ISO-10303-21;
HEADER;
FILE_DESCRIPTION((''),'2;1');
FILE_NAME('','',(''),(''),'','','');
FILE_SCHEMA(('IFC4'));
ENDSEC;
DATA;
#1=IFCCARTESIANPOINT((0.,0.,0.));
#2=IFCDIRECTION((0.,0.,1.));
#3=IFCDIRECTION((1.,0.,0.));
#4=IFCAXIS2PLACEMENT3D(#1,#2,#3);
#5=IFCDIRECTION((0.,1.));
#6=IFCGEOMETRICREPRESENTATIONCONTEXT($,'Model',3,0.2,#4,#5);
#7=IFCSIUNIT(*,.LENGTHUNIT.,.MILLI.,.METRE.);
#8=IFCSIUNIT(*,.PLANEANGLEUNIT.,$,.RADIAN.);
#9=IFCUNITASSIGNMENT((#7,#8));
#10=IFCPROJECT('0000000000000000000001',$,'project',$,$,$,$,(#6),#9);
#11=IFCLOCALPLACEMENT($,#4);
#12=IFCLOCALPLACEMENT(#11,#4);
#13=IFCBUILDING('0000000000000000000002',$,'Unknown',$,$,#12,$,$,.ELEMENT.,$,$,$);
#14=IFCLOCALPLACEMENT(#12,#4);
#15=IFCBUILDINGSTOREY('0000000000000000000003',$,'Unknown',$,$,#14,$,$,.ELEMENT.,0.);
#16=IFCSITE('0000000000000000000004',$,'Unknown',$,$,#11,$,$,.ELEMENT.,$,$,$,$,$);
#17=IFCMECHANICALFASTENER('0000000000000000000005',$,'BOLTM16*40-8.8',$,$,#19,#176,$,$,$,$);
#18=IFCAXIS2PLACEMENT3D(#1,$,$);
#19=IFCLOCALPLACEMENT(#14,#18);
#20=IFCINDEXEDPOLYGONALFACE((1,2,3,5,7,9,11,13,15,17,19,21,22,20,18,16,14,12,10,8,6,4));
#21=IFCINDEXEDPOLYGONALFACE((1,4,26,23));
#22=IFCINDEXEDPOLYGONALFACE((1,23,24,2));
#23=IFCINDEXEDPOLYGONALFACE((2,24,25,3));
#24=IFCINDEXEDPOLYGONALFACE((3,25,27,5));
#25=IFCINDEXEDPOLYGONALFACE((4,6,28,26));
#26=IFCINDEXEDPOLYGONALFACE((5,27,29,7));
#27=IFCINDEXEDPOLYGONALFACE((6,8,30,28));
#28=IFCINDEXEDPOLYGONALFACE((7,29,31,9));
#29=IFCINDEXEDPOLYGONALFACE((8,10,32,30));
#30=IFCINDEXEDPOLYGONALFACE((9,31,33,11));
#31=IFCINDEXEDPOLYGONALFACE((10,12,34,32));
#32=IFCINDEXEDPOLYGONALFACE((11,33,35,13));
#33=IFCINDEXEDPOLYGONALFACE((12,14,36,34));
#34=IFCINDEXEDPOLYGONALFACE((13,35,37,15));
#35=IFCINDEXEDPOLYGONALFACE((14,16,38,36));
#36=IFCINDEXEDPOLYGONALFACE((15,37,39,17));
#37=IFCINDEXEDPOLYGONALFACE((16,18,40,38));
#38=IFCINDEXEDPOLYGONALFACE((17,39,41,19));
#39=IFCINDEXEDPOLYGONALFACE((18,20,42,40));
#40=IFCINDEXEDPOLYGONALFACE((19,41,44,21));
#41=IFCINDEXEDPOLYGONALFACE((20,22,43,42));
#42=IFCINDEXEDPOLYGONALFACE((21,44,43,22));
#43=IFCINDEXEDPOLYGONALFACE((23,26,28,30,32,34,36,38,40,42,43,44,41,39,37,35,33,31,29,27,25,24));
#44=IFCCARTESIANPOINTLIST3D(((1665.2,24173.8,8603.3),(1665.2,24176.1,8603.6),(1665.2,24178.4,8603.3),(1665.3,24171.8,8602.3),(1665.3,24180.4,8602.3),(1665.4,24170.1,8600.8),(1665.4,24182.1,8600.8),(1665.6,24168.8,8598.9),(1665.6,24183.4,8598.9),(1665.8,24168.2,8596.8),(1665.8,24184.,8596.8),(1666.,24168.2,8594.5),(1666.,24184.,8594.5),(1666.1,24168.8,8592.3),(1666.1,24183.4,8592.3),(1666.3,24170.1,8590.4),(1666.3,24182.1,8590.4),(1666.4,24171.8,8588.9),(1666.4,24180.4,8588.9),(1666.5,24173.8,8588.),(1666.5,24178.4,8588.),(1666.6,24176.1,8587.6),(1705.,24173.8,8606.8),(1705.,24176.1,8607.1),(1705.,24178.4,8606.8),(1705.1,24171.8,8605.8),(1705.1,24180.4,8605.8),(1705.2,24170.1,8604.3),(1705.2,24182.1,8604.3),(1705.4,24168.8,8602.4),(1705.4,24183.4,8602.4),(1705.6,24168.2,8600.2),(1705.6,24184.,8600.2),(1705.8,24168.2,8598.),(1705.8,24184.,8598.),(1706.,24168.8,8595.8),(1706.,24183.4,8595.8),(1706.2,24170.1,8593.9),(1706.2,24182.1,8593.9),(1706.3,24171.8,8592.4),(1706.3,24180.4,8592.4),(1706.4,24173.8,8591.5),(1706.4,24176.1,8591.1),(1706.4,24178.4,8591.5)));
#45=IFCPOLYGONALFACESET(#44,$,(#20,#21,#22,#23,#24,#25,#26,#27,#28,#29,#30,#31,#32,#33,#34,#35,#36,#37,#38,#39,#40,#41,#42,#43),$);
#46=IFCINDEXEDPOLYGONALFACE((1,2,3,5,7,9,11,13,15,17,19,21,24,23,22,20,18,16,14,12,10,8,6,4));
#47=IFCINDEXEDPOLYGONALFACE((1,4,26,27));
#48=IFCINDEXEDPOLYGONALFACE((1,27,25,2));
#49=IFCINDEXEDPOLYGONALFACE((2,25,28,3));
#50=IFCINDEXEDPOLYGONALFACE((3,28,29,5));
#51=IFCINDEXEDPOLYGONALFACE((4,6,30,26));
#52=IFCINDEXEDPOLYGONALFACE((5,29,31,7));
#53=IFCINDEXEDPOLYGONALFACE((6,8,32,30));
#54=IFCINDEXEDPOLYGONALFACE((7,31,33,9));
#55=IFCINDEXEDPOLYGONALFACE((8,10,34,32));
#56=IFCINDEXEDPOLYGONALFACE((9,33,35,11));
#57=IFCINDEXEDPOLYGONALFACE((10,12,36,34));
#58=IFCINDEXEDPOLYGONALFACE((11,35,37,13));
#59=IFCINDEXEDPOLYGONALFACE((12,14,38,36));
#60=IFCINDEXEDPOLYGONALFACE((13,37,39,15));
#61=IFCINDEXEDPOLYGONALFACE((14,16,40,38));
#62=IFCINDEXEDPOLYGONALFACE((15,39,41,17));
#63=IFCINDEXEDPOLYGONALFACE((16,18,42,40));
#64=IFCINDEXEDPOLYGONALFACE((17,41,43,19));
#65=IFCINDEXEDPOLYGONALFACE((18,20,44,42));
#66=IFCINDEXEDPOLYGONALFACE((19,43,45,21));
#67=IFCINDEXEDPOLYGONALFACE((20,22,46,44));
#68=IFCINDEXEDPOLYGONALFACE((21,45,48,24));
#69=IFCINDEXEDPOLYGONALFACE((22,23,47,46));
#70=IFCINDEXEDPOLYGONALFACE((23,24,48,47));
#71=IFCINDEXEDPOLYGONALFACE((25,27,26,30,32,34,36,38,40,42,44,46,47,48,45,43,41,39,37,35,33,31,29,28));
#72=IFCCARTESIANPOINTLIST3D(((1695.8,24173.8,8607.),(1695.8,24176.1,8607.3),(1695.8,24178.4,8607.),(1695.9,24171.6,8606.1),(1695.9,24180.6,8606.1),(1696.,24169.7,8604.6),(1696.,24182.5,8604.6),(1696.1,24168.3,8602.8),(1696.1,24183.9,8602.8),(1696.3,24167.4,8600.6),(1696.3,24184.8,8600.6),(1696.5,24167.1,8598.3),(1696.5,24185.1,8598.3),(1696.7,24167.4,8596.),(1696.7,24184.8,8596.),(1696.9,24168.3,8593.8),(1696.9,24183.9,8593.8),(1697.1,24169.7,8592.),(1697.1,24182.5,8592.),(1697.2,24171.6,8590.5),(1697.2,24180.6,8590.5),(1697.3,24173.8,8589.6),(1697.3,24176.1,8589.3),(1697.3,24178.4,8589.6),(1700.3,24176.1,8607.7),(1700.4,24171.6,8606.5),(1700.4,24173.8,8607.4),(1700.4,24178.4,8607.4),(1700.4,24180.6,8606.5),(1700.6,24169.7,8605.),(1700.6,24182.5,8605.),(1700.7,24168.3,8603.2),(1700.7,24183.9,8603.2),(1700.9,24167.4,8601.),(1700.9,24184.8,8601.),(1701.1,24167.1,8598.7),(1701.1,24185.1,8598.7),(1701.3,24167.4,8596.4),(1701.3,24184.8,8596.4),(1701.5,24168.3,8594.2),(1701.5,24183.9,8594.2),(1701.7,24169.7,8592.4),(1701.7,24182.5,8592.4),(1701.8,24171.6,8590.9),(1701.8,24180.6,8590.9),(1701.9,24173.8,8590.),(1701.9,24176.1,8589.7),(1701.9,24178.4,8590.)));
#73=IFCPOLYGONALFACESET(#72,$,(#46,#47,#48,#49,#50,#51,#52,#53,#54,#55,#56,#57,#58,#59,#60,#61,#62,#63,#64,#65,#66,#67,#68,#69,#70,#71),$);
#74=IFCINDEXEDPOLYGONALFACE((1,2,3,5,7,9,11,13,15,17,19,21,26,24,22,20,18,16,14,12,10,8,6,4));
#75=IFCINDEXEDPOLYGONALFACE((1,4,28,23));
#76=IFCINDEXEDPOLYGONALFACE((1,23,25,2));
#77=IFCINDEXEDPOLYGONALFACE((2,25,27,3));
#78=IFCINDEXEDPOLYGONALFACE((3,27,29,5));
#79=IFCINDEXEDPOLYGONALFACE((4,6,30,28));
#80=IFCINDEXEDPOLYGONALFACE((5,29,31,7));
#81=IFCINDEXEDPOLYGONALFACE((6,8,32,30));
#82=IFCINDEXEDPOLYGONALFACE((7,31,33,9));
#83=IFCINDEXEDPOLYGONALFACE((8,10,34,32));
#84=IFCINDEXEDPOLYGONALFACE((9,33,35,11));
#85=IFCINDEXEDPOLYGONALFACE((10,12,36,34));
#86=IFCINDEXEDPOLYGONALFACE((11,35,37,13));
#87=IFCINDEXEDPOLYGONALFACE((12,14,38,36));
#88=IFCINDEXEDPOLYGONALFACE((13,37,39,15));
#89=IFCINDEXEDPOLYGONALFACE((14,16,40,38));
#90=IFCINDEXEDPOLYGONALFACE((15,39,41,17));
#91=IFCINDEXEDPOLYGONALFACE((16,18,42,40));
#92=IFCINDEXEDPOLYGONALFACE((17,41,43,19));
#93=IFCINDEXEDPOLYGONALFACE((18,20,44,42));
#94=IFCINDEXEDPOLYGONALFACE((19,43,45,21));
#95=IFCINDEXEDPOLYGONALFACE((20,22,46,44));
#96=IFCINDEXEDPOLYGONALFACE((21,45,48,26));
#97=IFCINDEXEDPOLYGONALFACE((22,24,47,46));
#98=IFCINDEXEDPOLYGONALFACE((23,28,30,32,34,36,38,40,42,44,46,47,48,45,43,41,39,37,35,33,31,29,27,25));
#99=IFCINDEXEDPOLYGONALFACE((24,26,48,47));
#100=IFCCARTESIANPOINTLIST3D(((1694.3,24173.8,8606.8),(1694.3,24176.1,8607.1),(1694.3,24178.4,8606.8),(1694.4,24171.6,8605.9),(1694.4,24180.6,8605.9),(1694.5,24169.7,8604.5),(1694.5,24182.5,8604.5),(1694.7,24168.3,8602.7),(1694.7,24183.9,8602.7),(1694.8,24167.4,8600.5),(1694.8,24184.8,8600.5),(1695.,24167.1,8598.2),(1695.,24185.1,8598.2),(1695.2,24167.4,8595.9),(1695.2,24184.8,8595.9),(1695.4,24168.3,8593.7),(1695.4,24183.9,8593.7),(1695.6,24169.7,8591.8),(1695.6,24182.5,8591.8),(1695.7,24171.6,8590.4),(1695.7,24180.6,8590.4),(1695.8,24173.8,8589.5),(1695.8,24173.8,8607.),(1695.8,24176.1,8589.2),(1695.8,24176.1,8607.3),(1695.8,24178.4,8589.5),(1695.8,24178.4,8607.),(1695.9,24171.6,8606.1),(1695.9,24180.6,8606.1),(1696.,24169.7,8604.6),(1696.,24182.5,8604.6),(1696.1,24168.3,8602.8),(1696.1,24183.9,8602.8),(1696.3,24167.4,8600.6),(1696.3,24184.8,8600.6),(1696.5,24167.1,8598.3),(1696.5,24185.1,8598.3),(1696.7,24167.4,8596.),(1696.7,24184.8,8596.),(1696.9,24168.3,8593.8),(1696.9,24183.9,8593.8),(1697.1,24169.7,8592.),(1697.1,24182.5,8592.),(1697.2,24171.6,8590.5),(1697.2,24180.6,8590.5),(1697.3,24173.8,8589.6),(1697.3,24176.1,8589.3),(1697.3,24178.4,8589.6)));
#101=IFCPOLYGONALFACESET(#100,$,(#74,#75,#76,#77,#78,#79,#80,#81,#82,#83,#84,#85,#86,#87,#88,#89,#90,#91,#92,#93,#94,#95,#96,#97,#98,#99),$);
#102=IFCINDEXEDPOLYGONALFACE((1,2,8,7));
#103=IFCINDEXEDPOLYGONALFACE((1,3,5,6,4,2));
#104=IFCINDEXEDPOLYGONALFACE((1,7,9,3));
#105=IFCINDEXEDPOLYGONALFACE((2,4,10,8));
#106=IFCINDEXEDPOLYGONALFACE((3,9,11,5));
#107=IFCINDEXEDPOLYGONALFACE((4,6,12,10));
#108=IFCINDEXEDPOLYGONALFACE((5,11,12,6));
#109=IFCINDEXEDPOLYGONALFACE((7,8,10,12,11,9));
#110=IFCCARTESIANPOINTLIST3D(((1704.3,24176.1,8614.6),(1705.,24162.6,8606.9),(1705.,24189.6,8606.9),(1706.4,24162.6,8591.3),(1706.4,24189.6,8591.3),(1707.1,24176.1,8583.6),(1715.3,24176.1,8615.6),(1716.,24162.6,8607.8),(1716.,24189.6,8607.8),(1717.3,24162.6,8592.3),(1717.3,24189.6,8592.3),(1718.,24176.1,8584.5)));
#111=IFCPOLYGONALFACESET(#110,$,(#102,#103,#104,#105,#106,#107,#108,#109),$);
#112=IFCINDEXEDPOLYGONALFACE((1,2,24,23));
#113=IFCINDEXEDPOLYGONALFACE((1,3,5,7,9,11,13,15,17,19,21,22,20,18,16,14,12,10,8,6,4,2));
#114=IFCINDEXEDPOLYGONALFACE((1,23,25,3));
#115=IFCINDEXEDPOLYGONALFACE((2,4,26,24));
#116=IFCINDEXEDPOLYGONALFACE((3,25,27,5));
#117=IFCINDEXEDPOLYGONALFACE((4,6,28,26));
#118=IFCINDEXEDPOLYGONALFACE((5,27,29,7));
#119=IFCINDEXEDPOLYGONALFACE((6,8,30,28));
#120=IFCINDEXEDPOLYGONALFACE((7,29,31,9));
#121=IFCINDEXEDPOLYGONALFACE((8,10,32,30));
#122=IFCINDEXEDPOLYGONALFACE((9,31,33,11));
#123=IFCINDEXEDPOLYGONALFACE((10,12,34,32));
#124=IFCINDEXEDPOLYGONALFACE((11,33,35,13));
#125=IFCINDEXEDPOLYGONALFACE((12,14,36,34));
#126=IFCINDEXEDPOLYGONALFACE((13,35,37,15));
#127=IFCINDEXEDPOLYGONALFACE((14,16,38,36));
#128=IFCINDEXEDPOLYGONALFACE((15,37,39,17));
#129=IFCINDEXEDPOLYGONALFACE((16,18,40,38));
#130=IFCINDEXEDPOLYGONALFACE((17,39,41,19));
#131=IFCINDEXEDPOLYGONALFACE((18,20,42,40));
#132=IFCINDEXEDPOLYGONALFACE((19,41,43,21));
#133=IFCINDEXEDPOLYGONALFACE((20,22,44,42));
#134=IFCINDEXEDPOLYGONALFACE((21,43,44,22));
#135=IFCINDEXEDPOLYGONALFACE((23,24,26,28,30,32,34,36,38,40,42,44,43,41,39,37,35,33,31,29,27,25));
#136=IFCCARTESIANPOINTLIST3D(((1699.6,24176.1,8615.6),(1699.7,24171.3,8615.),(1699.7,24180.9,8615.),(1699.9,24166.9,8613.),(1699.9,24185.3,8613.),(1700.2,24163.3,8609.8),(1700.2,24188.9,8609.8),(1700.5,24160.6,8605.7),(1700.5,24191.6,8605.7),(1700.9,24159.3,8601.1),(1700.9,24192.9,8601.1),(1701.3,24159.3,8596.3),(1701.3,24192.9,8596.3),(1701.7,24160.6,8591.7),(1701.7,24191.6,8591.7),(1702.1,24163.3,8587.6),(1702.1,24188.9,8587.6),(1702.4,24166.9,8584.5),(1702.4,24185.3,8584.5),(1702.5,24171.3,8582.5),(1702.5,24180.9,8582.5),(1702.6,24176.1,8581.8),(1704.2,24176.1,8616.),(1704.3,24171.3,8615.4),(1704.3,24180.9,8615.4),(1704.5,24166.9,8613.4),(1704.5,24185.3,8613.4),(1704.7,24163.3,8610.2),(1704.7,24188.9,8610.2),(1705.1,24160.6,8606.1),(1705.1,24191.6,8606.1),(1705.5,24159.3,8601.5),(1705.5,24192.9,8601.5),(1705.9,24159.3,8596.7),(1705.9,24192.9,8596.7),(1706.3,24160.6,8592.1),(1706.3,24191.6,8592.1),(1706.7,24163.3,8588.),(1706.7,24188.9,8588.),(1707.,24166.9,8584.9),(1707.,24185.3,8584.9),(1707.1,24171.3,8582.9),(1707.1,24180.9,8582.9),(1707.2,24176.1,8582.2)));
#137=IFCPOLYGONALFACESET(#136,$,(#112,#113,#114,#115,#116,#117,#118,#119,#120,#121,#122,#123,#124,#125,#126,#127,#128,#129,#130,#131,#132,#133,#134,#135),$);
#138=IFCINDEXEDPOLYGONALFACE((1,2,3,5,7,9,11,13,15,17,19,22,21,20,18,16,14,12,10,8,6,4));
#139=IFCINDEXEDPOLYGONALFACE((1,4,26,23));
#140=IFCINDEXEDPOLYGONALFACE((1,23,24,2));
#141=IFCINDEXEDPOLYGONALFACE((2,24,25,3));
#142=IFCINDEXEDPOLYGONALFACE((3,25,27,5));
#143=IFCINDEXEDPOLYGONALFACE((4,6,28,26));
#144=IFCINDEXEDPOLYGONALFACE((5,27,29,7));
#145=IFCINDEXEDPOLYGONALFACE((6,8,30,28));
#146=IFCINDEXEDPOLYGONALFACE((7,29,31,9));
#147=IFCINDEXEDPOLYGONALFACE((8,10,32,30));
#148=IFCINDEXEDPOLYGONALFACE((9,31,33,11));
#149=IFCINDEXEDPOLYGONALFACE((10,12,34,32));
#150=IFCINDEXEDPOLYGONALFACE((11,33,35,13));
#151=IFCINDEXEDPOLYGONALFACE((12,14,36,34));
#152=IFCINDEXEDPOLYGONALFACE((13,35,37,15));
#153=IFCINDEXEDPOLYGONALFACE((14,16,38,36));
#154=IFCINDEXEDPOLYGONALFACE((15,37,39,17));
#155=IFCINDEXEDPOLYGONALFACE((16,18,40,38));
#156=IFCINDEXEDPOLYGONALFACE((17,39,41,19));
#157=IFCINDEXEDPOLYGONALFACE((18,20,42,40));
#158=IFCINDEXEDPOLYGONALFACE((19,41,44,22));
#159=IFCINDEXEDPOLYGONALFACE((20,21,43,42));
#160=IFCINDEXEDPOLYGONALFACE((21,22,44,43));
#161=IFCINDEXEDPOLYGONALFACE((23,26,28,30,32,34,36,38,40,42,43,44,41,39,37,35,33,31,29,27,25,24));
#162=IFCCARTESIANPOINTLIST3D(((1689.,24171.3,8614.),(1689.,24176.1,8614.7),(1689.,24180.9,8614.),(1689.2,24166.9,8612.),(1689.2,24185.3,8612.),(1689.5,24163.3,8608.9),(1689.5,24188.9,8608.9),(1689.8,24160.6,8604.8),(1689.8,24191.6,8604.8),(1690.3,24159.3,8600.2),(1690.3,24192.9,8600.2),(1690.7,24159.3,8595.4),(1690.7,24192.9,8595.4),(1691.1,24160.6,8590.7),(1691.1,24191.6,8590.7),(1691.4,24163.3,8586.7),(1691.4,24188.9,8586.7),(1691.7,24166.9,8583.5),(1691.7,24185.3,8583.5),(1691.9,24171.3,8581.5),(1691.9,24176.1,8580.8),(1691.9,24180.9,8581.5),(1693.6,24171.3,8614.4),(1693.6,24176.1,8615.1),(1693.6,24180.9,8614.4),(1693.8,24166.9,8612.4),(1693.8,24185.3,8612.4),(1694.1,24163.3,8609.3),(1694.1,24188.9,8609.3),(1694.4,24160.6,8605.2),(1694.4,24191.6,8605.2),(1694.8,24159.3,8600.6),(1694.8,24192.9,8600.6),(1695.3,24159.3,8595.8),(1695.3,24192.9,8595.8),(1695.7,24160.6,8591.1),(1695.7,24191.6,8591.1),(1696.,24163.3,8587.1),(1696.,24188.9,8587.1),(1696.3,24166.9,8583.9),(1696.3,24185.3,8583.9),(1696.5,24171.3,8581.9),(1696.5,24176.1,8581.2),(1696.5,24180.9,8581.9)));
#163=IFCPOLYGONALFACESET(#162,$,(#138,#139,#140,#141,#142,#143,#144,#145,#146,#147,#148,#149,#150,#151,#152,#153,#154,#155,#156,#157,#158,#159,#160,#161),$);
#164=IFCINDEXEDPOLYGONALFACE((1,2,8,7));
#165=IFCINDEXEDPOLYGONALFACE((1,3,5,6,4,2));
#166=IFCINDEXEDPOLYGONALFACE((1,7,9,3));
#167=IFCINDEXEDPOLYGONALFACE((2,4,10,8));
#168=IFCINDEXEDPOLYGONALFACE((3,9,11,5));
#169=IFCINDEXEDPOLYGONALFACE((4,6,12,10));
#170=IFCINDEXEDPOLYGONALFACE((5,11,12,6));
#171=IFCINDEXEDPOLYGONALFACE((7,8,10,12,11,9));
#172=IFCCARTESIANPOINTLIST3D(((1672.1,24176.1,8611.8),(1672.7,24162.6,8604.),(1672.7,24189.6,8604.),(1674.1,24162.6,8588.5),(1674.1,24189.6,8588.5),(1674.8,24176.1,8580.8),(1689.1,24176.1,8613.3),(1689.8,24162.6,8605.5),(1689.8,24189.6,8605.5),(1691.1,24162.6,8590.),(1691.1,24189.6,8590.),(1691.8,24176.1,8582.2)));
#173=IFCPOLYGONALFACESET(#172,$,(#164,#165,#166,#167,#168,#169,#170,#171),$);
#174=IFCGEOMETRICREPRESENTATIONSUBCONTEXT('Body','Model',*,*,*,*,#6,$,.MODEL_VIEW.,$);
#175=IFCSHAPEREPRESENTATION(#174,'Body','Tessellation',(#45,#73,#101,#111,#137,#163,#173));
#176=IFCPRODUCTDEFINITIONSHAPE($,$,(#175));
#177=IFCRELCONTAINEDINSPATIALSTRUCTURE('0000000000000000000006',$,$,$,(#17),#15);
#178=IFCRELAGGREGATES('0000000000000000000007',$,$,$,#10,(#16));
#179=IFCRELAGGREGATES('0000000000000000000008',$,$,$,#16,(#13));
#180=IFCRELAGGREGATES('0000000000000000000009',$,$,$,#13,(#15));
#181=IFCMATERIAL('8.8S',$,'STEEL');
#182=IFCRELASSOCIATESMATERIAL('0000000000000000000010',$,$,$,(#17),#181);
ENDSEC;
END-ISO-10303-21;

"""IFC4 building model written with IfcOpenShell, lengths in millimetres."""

from ifc_helpers import new_model, si_unit, direction, frame, origin_with_axes, place, context, subcontext, project, spatial, line, arc, indexed_curve, outline, extrude, source, transform, mapped, material, element, save


model = new_model("IFC4")

# Units and contexts
model_context = context("Model", 3, precision=0.2, world=origin_with_axes(), true_north=direction((0.0, 1.0)))
body_context = subcontext(model_context, "Body", "Model", "MODEL_VIEW")
ifc_project = project(units=[si_unit("LENGTHUNIT", "METRE", prefix="MILLI"), si_unit("PLANEANGLEUNIT", "RADIAN")], contexts=[model_context])

# Site, building, storey
site_placement = place(None, origin_with_axes())
site = spatial("IfcSite", under=ifc_project, at=site_placement, Name="Unknown", CompositionType="ELEMENT")
building_placement = place(site_placement, origin_with_axes())
building = spatial("IfcBuilding", under=site, at=building_placement, Name="Unknown", CompositionType="ELEMENT")
storey_placement = place(building_placement, origin_with_axes())
storey = spatial("IfcBuildingStorey", under=building, at=storey_placement, Name="Unknown", CompositionType="ELEMENT", Elevation=0.0)

# Mechanical fastener
ifc_material_1 = material(Name="8.8S", Category="STEEL")
shared_shape_1 = source(origin_with_axes(), body_context, "Body", "SweptSolid", [
    extrude(outline(indexed_curve([(8.0, 0.0), (0.0, 8.0), (-8.0, 0.0), (0.0, -8.0)], segments=[arc(1, 2, 3), arc(3, 4, 1)])), frame((0.0, 0.0, 9.2), z_axis=(0.0, 0.0, -1.0), x_axis=(0.0, 1.0, 0.0)), (0.0, 0.0, 1.0), 40.0),
    extrude(outline(indexed_curve([(0.0, 9.0), (6.4, 6.4), (9.0, 0.0), (6.4, -6.4), (0.0, -9.0), (-0.8, -9.0), (-9.0, 0.0), (-6.4, 6.4)], segments=[arc(1, 2, 3), arc(3, 4, 5), arc(5, 6, 7), arc(7, 8, 1)])), frame((0.0, 0.0, 4.6), z_axis=(0.0, 0.0, -1.0), x_axis=(0.0, 1.0, 0.0)), (0.0, 0.0, 1.0), 4.6),
    extrude(outline(indexed_curve([(0.0, 9.0), (6.4, 6.4), (9.0, 0.0), (6.4, -6.4), (0.0, -9.0), (-0.8, -9.0), (-9.0, 0.0), (-6.4, 6.4)], segments=[arc(1, 2, 3), arc(3, 4, 5), arc(5, 6, 7), arc(7, 8, 1)])), frame((0.0, 0.0, 0.0), z_axis=(0.0, 0.0, -1.0), x_axis=(0.0, 1.0, 0.0)), (0.0, 0.0, 1.0), 1.5),
    extrude(outline(indexed_curve([(15.6, 0.0), (7.8, 13.5), (-7.8, 13.5), (-15.6, 0.0), (-7.8, -13.5), (7.8, -13.5)], segments=[line(1, 2, 3, 4, 5, 6, 1)])), frame((0.0, 0.0, 20.2), z_axis=(0.0, 0.0, -1.0), x_axis=(0.0, 1.0, 0.0)), (0.0, 0.0, 1.0), 11.0),
    extrude(outline(indexed_curve([(17.0, 0.0), (0.0, 17.0), (-17.0, 0.0), (0.0, -17.0)], segments=[arc(1, 2, 3), arc(3, 4, 1)])), frame((0.0, 0.0, 9.2), z_axis=(0.0, 0.0, -1.0), x_axis=(0.0, 1.0, 0.0)), (0.0, 0.0, 1.0), 4.6),
    extrude(outline(indexed_curve([(17.0, 0.0), (0.0, 17.0), (-17.0, 0.0), (0.0, -17.0)], segments=[arc(1, 2, 3), arc(3, 4, 1)])), frame((0.0, 0.0, -1.5), z_axis=(0.0, 0.0, -1.0), x_axis=(0.0, 1.0, 0.0)), (0.0, 0.0, 1.0), 4.6),
    extrude(outline(indexed_curve([(15.6, 0.0), (7.8, 13.5), (-7.8, 13.5), (-15.6, 0.0), (-7.8, -13.5), (7.8, -13.5)], segments=[line(1, 2, 3, 4, 5, 6, 1)])), frame((0.0, 0.0, -6.1), z_axis=(0.0, 0.0, -1.0), x_axis=(0.0, 1.0, 0.0)), (0.0, 0.0, 1.0), 17.1),
])
mechanical_fastener_1_placement = place(storey_placement, frame((1696.5, 24176.1, 8598.3), z_axis=(0.996195, 0.0, 0.087156), x_axis=(0.0, 1.0, 0.0)))
element("IfcMechanicalFastener", 1, at=mechanical_fastener_1_placement, inside=storey, material=ifc_material_1, Name="BOLTM16*40-8.8", context=body_context, shape_type="MappedRepresentation", body=[
    mapped(shared_shape_1, transform((0.0, 0.0, 0.0))),
])

save(model, "model.ifc")
